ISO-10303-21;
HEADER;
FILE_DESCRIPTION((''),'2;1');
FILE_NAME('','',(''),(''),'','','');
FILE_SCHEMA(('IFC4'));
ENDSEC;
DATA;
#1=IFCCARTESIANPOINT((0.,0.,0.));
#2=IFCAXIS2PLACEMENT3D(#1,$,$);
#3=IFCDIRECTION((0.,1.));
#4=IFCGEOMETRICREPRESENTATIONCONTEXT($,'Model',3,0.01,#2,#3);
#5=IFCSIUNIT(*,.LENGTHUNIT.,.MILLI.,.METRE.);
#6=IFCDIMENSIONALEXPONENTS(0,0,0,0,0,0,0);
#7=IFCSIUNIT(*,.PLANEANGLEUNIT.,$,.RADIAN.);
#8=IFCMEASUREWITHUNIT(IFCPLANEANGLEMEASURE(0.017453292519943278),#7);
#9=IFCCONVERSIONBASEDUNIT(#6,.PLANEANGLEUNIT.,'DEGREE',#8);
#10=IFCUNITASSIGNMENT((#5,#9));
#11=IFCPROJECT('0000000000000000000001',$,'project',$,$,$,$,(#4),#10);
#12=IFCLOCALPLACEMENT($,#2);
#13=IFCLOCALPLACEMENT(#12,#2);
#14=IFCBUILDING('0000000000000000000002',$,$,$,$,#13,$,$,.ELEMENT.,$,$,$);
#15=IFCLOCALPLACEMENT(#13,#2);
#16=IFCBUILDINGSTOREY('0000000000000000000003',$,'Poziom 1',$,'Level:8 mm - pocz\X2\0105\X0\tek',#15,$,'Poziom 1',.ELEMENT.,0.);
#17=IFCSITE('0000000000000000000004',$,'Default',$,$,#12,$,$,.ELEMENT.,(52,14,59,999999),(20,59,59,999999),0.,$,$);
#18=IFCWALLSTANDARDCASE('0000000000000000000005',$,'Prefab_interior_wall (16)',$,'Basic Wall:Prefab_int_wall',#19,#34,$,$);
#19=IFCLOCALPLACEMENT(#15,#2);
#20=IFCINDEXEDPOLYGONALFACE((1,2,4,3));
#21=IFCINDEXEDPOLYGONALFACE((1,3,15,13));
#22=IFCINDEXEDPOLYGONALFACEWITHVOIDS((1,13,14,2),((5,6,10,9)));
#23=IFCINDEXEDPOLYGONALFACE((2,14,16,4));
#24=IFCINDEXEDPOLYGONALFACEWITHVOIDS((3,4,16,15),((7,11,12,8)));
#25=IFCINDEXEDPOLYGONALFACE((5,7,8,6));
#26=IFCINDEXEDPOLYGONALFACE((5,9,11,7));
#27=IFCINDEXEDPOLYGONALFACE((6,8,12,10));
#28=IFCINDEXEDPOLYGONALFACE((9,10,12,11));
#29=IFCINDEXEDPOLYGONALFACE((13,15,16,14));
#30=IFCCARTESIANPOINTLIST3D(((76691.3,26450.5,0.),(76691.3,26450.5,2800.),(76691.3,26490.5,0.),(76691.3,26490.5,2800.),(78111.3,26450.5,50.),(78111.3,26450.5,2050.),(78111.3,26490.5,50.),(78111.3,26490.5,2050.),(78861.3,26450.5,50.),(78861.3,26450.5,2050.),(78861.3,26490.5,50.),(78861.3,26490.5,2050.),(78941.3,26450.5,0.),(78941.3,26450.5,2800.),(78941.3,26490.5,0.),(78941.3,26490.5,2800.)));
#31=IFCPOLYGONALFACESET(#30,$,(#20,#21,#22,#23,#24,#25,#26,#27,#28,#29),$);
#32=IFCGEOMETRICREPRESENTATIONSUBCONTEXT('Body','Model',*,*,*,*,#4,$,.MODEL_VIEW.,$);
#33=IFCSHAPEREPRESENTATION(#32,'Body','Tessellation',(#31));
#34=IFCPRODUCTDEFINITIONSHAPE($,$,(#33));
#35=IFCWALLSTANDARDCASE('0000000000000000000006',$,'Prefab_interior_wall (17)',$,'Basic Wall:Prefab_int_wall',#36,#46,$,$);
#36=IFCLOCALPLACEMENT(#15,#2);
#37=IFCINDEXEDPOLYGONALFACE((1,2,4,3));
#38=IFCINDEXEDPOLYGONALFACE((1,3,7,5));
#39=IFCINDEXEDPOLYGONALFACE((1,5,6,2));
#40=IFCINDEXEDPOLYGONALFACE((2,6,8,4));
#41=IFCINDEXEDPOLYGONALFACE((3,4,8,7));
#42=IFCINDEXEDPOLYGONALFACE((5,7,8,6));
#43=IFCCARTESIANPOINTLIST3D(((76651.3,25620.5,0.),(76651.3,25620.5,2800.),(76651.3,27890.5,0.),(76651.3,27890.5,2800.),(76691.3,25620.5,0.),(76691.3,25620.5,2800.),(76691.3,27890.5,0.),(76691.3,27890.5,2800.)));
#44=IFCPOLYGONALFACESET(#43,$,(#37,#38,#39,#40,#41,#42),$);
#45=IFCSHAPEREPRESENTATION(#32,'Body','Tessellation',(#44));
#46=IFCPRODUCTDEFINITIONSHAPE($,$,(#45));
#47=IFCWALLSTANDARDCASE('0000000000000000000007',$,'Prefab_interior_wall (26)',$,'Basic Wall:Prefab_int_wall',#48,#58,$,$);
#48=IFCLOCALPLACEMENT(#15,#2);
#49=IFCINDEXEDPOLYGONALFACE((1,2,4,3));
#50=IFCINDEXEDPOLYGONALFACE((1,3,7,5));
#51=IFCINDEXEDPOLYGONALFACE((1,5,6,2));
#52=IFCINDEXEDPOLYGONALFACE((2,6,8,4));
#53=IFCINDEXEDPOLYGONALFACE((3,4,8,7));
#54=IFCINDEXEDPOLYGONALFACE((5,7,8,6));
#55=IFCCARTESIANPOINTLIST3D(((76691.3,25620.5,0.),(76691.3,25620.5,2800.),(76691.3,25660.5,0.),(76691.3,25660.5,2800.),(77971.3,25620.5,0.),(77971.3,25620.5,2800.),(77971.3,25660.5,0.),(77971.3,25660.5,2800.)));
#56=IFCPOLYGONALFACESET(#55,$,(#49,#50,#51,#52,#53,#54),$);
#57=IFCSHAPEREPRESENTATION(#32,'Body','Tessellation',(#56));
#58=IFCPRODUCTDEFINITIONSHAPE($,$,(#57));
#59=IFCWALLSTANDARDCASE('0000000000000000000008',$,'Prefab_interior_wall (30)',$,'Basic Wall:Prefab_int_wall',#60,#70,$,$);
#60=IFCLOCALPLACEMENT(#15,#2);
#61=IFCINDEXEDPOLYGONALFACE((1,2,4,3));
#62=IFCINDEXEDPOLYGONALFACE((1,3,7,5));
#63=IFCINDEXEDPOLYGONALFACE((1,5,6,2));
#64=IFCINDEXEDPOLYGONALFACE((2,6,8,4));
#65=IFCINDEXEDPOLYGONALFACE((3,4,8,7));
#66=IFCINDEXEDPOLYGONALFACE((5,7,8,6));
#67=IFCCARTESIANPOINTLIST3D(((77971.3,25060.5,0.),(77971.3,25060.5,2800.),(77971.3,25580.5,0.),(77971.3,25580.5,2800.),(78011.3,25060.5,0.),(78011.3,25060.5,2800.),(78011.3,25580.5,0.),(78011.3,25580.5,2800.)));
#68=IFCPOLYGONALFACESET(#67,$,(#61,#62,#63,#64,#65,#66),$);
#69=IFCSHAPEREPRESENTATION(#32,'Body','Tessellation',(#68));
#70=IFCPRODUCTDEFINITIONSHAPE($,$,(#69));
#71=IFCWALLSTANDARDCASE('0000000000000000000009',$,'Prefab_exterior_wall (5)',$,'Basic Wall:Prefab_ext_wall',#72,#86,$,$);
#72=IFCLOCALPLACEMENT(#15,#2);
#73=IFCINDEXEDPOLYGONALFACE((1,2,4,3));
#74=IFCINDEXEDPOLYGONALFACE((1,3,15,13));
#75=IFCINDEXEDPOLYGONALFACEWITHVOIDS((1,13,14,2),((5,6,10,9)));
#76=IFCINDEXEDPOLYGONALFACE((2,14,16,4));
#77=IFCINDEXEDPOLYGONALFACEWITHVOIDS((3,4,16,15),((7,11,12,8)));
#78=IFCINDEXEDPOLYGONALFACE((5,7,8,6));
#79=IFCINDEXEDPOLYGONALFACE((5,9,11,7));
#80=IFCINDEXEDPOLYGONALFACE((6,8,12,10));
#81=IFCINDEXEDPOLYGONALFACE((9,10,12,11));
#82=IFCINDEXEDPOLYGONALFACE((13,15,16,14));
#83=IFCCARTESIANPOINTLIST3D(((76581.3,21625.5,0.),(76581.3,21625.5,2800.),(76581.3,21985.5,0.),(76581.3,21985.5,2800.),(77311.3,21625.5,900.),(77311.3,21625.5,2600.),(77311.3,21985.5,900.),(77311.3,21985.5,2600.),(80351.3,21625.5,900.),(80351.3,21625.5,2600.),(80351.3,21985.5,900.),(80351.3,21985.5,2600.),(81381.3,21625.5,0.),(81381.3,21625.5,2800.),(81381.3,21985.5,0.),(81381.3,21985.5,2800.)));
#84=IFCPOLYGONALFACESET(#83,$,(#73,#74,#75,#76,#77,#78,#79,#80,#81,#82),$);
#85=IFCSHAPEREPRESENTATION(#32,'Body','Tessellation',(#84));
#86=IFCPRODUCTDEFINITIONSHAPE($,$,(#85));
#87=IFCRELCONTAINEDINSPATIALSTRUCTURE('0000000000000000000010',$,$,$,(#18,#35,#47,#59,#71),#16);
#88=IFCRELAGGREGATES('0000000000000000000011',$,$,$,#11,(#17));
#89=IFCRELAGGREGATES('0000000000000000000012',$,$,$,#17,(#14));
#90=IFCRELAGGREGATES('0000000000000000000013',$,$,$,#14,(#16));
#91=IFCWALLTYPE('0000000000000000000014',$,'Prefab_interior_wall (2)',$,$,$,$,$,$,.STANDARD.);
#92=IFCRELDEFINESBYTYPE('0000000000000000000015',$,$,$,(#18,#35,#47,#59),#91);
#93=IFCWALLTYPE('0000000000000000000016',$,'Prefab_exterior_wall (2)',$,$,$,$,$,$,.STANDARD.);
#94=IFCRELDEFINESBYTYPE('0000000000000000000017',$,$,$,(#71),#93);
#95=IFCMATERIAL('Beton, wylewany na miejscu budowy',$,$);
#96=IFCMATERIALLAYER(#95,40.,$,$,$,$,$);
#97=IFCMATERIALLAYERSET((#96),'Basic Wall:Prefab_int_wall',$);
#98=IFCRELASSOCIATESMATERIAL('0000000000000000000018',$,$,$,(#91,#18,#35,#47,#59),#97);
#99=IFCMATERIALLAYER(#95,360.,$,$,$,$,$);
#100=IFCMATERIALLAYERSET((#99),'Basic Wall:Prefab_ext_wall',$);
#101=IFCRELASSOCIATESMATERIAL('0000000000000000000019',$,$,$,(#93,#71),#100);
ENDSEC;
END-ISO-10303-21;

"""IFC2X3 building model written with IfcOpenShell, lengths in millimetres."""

from ifc_helpers import new_model, entity, si_unit, converted_unit, direction, frame, frame_2d, origin, origin_2d_with_axis, place, context, subcontext, project, spatial, rectangle, extrude, material, layer, layer_set, layer_usage, type_object, element, save


model = new_model("IFC2X3")

# Units and contexts
model_context = context("Model", 3, precision=0.01, world=origin(), true_north=direction((0.0, 1.0)))
body_context = subcontext(model_context, "Body", "Model", "MODEL_VIEW")
ifc_project = project(units=[si_unit("LENGTHUNIT", "METRE", prefix="MILLI"), converted_unit("PLANEANGLEUNIT", "DEGREE", entity("IfcPlaneAngleMeasure", 0.017453292519943278), si_unit("PLANEANGLEUNIT", "RADIAN"), dimensions=[0, 0, 0, 0, 0, 0, 0])], contexts=[model_context])

# Site, building, storey
site_placement = place(None, origin())
site = spatial("IfcSite", under=ifc_project, at=site_placement, Name="Default", CompositionType="ELEMENT", RefLatitude=(52, 14, 59, 999999), RefLongitude=(20, 59, 59, 999999), RefElevation=0.0)
building_placement = place(site_placement, origin())
building = spatial("IfcBuilding", under=site, at=building_placement, CompositionType="ELEMENT")
storey_placement = place(building_placement, origin())
storey = spatial("IfcBuildingStorey", under=building, at=storey_placement, Name="Poziom 1", ObjectType="Level:8 mm - początek", LongName="Poziom 1", CompositionType="ELEMENT", Elevation=0.0)

# Shared definitions
ifc_material_1 = material(Name="Beton, wylewany na miejscu budowy")

# Shared definitions
ifc_layer_1 = layer(ifc_material_1, 40.0)
ifc_layer_set_1 = layer_set([ifc_layer_1], Name="Basic Wall:Prefab_int_wall")
wall_type_1 = type_object("IfcWallType", Name="Prefab_interior_wall (2)", PredefinedType="STANDARD", material=ifc_layer_set_1)

# Wall, opening
ifc_layer_usage_1 = layer_usage(ifc_layer_set_1, "AXIS2", "NEGATIVE", 20.0)
wall_1_placement = place(storey_placement, frame((78941.3, 26470.5, 0.0), z_axis=(0.0, 0.0, 1.0), x_axis=(-1.0, 0.0, 0.0)))
wall_1 = element("IfcWallStandardCase", 1, at=wall_1_placement, inside=storey, type_object=wall_type_1, material=ifc_layer_usage_1, Name="Prefab_interior_wall (16)", ObjectType="Basic Wall:Prefab_int_wall", context=body_context, shape_type="SweptSolid", body=[
    extrude(rectangle(XDim=2250.0, YDim=40.0, at=frame_2d((1125.0, 0.0), x_axis=(-1.0, 0.0))), origin(), (0.0, 0.0, 1.0), 2800.0),
])
opening_1_placement = place(wall_1_placement, origin())
element("IfcOpeningElement", 2, at=opening_1_placement, cuts=wall_1, ObjectType="Opening", context=body_context, shape_type="SweptSolid", body=[
    extrude(rectangle(XDim=2000.0, YDim=750.0, at=origin_2d_with_axis()), frame((455.0, 20.0, 1050.0), z_axis=(0.0, -1.0, 0.0), x_axis=(0.0, 0.0, 1.0)), (0.0, 0.0, 1.0), 40.0),
])

# Walls
ifc_layer_usage_2 = layer_usage(ifc_layer_set_1, "AXIS2", "NEGATIVE", 20.0)
wall_2_placement = place(storey_placement, frame((76671.3, 25620.5, 0.0), z_axis=(0.0, 0.0, 1.0), x_axis=(0.0, 1.0, 0.0)))
element("IfcWallStandardCase", 3, at=wall_2_placement, inside=storey, type_object=wall_type_1, material=ifc_layer_usage_2, Name="Prefab_interior_wall (17)", ObjectType="Basic Wall:Prefab_int_wall", context=body_context, shape_type="SweptSolid", body=[
    extrude(rectangle(XDim=2270.0, YDim=40.0, at=frame_2d((1135.0, 0.0), x_axis=(-1.0, 0.0))), origin(), (0.0, 0.0, 1.0), 2800.0),
])
ifc_layer_usage_3 = layer_usage(ifc_layer_set_1, "AXIS2", "NEGATIVE", 20.0)
wall_3_placement = place(storey_placement, frame((77971.3, 25640.5, 0.0), z_axis=(0.0, 0.0, 1.0), x_axis=(-1.0, 0.0, 0.0)))
element("IfcWallStandardCase", 4, at=wall_3_placement, inside=storey, type_object=wall_type_1, material=ifc_layer_usage_3, Name="Prefab_interior_wall (26)", ObjectType="Basic Wall:Prefab_int_wall", context=body_context, shape_type="SweptSolid", body=[
    extrude(rectangle(XDim=1280.0, YDim=40.0, at=frame_2d((640.0, 0.0), x_axis=(-1.0, 0.0))), origin(), (0.0, 0.0, 1.0), 2800.0),
])
ifc_layer_usage_4 = layer_usage(ifc_layer_set_1, "AXIS2", "NEGATIVE", 20.0)
wall_4_placement = place(storey_placement, frame((77991.3, 25580.5, 0.0), z_axis=(0.0, 0.0, 1.0), x_axis=(0.0, -1.0, 0.0)))
element("IfcWallStandardCase", 5, at=wall_4_placement, inside=storey, type_object=wall_type_1, material=ifc_layer_usage_4, Name="Prefab_interior_wall (30)", ObjectType="Basic Wall:Prefab_int_wall", context=body_context, shape_type="SweptSolid", body=[
    extrude(rectangle(XDim=520.0, YDim=40.0, at=frame_2d((260.0, 0.0), x_axis=(-1.0, 0.0))), origin(), (0.0, 0.0, 1.0), 2800.0),
])

# Wall, opening
ifc_layer_2 = layer(ifc_material_1, 360.0)
ifc_layer_set_2 = layer_set([ifc_layer_2], Name="Basic Wall:Prefab_ext_wall")
wall_type_2 = type_object("IfcWallType", Name="Prefab_exterior_wall (2)", PredefinedType="STANDARD", material=ifc_layer_set_2)
ifc_layer_usage_5 = layer_usage(ifc_layer_set_2, "AXIS2", "NEGATIVE", 180.0)
wall_5_placement = place(storey_placement, frame((76581.3, 21805.5, 0.0)))
wall_5 = element("IfcWallStandardCase", 6, at=wall_5_placement, inside=storey, type_object=wall_type_2, material=ifc_layer_usage_5, Name="Prefab_exterior_wall (5)", ObjectType="Basic Wall:Prefab_ext_wall", context=body_context, shape_type="SweptSolid", body=[
    extrude(rectangle(XDim=4800.0, YDim=360.0, at=frame_2d((2400.0, 0.0), x_axis=(-1.0, 0.0))), origin(), (0.0, 0.0, 1.0), 2800.0),
])
opening_2_placement = place(wall_5_placement, origin())
element("IfcOpeningElement", 7, at=opening_2_placement, cuts=wall_5, ObjectType="Opening", context=body_context, shape_type="SweptSolid", body=[
    extrude(rectangle(XDim=1700.0, YDim=3040.0, at=origin_2d_with_axis()), frame((2250.0, 180.0, 1750.0), z_axis=(0.0, -1.0, 0.0), x_axis=(0.0, 0.0, -1.0)), (0.0, 0.0, 1.0), 360.0),
])

save(model, "model.ifc")
